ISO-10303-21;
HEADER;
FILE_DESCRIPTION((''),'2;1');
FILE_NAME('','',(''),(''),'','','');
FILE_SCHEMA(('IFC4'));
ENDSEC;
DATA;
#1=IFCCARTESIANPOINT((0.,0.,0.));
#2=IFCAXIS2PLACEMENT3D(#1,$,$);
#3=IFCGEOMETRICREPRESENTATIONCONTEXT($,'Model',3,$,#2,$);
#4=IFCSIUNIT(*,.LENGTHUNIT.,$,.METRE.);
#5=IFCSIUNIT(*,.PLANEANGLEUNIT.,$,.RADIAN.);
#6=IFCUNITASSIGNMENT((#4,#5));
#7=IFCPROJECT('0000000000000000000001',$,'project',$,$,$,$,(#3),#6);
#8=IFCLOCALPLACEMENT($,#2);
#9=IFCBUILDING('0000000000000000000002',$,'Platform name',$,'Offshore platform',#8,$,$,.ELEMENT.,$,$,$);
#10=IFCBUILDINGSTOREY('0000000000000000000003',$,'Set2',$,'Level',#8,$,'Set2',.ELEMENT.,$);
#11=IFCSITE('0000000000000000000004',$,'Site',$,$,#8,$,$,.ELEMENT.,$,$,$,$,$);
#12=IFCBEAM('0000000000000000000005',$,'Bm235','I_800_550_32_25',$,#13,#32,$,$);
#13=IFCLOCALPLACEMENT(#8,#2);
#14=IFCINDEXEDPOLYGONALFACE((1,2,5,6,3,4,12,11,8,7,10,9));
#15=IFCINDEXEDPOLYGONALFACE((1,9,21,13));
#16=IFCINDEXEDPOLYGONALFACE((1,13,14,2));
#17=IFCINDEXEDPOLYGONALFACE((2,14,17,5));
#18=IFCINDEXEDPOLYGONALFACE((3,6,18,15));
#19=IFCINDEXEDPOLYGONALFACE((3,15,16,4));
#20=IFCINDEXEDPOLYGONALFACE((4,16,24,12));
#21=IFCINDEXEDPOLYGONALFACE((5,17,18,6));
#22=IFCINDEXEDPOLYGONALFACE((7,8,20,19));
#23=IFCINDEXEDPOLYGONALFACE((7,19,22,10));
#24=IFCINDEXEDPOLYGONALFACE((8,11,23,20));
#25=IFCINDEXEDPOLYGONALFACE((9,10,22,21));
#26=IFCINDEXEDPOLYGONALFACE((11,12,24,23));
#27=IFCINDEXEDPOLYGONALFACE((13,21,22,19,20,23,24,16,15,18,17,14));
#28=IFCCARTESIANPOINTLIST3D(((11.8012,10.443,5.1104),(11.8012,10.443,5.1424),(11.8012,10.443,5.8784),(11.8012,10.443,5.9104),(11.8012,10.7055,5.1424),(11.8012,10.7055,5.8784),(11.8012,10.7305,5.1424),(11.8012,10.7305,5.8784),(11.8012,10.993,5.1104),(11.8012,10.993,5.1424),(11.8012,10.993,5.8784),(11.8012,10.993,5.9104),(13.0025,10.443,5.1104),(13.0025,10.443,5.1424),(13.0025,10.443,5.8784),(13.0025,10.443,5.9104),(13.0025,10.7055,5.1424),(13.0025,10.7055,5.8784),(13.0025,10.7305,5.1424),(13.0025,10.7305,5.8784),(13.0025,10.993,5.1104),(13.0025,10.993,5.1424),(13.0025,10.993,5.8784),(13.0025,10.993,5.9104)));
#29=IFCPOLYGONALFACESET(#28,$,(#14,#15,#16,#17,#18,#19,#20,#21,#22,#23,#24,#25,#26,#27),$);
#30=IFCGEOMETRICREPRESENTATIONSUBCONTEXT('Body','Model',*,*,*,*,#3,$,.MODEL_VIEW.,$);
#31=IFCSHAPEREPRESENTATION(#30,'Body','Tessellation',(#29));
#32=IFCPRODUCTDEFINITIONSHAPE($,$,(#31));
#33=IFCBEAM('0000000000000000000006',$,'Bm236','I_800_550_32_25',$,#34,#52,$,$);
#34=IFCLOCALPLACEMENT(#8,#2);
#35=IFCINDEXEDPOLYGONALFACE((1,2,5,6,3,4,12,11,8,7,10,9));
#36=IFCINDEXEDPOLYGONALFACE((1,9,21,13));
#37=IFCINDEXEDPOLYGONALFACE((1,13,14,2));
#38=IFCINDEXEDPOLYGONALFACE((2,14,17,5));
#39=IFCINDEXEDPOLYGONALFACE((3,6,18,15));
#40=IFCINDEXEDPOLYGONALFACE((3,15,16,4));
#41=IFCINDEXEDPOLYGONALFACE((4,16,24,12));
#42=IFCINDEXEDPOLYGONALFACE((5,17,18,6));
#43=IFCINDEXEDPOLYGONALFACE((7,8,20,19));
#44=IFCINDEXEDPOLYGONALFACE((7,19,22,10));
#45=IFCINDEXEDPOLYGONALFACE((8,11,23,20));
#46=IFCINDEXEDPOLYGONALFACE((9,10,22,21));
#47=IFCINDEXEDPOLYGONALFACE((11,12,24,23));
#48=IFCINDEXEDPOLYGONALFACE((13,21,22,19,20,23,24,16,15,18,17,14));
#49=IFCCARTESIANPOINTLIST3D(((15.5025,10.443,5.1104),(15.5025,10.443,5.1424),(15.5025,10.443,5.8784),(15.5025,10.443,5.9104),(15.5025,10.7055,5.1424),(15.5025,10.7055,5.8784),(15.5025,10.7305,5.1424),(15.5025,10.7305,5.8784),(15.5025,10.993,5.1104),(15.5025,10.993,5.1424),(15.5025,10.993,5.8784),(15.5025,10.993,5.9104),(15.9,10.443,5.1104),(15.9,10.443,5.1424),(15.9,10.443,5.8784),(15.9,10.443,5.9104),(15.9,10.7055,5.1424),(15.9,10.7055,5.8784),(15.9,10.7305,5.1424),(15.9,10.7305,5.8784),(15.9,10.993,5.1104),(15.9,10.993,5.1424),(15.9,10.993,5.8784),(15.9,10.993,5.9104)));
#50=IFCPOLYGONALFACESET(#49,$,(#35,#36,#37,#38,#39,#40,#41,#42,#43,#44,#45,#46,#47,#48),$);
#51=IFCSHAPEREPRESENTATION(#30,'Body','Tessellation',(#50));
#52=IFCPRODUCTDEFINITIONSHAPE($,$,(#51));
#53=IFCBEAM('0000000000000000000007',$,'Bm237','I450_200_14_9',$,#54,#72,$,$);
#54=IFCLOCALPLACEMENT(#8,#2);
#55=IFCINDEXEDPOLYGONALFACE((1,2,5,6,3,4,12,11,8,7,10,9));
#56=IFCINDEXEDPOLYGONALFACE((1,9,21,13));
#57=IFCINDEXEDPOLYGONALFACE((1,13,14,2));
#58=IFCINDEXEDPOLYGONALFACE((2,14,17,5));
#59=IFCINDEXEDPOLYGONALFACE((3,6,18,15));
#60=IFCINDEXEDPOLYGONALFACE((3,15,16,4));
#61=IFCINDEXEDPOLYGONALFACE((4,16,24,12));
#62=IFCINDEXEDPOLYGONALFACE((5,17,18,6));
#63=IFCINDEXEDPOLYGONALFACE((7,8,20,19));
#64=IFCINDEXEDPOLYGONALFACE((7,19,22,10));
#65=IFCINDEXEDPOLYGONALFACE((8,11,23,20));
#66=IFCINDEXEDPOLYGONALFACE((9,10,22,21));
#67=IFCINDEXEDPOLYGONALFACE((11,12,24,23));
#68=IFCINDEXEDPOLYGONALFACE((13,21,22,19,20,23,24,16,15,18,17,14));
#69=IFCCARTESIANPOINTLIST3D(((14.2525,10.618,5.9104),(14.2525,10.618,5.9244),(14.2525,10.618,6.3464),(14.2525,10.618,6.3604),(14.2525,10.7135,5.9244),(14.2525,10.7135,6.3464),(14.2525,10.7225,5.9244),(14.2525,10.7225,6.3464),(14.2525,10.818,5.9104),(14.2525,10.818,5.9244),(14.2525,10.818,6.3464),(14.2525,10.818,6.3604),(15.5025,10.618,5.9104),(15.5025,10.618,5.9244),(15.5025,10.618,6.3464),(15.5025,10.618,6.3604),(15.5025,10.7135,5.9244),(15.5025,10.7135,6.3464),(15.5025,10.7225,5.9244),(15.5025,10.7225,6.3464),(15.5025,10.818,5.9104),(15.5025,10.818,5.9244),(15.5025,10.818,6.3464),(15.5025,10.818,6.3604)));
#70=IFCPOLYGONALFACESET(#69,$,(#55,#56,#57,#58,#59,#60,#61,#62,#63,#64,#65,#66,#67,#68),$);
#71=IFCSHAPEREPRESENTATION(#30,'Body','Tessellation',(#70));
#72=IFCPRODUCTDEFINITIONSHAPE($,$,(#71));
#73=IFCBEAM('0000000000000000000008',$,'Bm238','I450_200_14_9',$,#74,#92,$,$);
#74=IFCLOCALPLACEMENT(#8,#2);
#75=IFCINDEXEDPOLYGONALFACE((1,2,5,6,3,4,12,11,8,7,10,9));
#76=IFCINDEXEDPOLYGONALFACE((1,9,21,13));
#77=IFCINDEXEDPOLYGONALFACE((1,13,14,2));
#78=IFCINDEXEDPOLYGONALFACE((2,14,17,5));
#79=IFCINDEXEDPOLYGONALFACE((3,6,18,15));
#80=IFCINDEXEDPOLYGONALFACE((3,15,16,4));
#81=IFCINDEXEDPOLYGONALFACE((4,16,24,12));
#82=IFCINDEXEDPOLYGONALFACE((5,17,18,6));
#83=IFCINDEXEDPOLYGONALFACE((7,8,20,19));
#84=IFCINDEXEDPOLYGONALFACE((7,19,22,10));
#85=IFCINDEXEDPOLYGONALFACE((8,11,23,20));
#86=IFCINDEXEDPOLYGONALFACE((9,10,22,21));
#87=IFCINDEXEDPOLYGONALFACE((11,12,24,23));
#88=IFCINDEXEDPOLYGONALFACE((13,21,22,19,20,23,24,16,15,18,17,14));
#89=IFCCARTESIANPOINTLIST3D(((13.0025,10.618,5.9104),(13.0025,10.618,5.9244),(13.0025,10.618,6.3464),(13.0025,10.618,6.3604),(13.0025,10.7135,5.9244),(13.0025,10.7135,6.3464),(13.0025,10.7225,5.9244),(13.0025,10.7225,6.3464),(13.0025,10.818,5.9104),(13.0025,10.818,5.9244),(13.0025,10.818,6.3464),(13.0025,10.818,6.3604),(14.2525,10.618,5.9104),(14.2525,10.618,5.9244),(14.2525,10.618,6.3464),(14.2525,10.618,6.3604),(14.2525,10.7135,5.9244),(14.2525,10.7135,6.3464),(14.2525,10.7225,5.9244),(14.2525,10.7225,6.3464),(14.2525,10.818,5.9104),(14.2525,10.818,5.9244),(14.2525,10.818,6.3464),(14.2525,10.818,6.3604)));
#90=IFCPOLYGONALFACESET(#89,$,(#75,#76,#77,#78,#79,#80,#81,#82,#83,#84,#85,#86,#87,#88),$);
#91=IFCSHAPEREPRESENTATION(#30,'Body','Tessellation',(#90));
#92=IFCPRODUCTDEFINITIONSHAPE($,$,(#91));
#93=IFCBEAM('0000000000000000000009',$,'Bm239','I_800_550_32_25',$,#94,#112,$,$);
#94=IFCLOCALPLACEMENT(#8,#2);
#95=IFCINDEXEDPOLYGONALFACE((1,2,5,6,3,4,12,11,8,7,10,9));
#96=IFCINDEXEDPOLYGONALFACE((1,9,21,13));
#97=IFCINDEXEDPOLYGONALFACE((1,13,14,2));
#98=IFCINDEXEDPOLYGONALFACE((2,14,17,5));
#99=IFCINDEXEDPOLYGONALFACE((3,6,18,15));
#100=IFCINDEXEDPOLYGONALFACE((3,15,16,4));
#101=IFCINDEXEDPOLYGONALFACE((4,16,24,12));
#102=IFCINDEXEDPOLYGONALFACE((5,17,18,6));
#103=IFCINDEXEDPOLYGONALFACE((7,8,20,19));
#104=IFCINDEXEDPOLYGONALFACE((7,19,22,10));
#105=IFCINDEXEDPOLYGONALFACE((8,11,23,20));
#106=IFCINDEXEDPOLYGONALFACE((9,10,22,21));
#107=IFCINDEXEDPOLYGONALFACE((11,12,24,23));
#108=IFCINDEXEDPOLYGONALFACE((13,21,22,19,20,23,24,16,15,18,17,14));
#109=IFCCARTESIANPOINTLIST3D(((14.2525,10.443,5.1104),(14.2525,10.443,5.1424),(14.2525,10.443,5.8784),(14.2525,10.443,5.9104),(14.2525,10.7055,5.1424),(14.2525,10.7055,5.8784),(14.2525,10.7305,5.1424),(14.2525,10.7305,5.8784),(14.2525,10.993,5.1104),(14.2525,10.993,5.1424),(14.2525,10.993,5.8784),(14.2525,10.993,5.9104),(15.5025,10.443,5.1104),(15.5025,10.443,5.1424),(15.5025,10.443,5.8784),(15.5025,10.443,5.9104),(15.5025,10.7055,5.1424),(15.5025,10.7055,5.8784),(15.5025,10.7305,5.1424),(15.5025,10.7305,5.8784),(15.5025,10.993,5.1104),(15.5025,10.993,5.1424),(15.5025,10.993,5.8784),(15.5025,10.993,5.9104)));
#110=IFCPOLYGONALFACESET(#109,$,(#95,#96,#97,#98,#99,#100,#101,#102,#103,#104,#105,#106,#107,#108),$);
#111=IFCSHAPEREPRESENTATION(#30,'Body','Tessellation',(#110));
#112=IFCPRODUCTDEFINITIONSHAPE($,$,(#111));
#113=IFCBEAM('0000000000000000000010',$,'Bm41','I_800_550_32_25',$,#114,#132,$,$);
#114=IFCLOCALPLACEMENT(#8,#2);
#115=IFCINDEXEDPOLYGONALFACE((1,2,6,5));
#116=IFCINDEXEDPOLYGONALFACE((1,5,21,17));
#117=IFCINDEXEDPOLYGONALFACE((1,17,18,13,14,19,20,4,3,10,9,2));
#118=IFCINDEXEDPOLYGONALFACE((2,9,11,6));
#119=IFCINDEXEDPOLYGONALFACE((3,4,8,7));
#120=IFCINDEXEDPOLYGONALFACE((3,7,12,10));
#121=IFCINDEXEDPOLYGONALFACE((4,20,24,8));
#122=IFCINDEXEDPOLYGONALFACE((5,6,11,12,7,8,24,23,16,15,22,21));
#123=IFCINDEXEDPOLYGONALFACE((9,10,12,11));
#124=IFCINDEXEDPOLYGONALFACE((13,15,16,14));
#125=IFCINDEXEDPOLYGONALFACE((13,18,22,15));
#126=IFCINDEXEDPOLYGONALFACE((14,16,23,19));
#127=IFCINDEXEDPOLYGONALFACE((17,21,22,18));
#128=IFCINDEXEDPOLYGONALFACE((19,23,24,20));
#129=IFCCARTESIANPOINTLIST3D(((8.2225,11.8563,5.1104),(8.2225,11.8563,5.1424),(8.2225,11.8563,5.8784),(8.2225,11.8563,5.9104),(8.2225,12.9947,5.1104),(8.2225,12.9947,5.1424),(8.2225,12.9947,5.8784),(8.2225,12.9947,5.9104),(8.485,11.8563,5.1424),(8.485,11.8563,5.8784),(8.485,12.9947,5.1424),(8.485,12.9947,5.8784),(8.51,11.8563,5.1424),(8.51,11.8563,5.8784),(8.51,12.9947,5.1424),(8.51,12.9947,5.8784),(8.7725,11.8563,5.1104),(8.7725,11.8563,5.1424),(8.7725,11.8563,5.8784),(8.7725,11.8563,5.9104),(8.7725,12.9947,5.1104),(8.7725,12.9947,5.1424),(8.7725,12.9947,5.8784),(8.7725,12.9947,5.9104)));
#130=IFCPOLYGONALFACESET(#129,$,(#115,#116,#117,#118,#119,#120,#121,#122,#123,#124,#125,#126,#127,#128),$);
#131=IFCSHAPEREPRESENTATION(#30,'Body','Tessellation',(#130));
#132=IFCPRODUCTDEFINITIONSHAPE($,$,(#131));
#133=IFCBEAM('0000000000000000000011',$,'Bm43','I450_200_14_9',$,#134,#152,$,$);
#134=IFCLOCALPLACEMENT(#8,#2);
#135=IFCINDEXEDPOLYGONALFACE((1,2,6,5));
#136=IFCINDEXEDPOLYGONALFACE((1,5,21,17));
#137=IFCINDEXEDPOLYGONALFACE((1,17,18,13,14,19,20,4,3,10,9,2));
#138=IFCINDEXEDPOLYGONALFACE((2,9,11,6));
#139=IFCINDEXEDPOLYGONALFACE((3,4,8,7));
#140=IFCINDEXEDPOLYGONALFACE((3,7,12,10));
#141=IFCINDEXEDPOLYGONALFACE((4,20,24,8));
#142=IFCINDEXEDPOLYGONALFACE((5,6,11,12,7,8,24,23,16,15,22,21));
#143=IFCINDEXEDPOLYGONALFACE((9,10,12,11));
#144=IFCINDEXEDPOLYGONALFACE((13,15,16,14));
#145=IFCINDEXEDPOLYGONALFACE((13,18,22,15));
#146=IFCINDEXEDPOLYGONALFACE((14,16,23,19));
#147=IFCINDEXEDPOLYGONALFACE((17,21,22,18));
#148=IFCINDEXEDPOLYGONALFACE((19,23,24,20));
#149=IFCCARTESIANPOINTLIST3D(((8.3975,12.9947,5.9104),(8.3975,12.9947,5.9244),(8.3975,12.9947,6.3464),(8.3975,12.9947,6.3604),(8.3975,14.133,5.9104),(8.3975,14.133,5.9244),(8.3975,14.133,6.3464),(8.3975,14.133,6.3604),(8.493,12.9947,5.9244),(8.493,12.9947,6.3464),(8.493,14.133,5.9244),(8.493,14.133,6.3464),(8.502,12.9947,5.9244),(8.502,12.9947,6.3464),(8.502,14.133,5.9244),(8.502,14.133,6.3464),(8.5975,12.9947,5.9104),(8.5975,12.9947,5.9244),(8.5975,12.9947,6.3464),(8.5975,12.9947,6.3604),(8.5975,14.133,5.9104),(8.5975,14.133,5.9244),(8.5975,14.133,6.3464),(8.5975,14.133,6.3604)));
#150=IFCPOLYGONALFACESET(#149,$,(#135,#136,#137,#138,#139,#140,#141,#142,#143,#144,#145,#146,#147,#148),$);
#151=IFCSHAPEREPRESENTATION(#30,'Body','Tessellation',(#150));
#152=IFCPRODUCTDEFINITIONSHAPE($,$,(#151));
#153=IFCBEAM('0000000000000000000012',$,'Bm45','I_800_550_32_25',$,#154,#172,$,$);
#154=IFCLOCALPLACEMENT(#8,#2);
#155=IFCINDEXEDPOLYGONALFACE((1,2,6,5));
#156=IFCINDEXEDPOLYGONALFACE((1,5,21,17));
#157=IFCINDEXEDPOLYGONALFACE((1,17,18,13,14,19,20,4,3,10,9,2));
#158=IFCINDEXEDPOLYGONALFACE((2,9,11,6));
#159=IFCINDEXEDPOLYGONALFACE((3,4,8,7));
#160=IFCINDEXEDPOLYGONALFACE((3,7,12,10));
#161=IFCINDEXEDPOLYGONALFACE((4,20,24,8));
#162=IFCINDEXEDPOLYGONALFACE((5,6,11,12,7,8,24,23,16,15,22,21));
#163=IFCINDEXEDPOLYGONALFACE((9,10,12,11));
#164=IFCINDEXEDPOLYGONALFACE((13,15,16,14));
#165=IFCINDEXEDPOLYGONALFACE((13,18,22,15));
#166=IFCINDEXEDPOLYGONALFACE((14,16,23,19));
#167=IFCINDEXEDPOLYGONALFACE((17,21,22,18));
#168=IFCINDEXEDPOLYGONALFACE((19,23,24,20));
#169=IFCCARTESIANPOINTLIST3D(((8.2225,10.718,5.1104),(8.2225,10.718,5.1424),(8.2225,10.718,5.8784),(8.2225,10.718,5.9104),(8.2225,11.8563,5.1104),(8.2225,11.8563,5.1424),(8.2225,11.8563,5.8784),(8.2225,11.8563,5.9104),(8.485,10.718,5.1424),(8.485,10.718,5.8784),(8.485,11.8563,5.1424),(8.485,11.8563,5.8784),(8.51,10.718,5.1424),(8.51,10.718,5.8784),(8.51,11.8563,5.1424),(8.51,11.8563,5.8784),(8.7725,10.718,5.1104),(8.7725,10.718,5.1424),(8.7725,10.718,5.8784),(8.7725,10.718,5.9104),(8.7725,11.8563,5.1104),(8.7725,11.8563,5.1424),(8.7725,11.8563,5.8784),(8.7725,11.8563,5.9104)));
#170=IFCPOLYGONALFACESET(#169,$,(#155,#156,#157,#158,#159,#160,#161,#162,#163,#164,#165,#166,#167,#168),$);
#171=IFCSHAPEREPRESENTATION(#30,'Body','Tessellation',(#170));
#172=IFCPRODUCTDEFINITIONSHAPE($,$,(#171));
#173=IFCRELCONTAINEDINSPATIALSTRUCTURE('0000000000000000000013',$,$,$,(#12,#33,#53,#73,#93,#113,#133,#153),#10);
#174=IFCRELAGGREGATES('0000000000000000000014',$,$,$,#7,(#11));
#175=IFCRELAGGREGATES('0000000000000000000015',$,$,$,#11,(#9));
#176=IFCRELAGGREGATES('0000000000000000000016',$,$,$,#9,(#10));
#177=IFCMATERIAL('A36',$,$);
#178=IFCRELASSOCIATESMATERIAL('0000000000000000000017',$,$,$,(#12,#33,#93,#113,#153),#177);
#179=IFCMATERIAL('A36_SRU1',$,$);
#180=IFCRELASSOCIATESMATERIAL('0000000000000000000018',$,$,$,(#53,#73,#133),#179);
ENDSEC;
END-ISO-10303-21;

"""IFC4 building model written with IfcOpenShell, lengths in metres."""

from ifc_helpers import new_model, si_unit, frame, origin, origin_2d, place, context, subcontext, project, spatial, i_section, extrude, source, transform, mapped, material, element, save


model = new_model("IFC4")

# Units and contexts
model_context = context("Model", 3, world=origin())
body_context = subcontext(model_context, "Body", "Model", "MODEL_VIEW")
ifc_project = project(units=[si_unit("LENGTHUNIT", "METRE"), si_unit("PLANEANGLEUNIT", "RADIAN")], contexts=[model_context])

# Site, building, storey
placement_1 = place(None, origin())
site = spatial("IfcSite", under=ifc_project, at=placement_1, Name="Site", CompositionType="ELEMENT")
building = spatial("IfcBuilding", under=site, at=placement_1, Name="Platform name", ObjectType="Offshore platform", CompositionType="ELEMENT")
storey = spatial("IfcBuildingStorey", under=building, at=placement_1, Name="Set2", ObjectType="Level", LongName="Set2", CompositionType="ELEMENT")

# Beams
ifc_material_1 = material(Name="A36_SRU1")
ifc_material_2 = material(Name="A36")
shared_shape_1 = source(origin(), body_context, "Body", "SweptSolid", [
    extrude(i_section(OverallWidth=0.55, OverallDepth=0.8, WebThickness=0.025, FlangeThickness=0.032, FilletRadius=0.0, at=origin_2d()), frame((0.0, 0.0, 0.0), z_axis=(1.0, 0.0, 0.0), x_axis=(0.0, 1.0, 0.0)), (0.0, 0.0, 1.0), 1.2012),
])
placement_2 = place(None, origin())
placement_3 = place(placement_2, origin())
placement_4 = place(placement_3, origin())
beam_1_placement = place(placement_4, frame((11.8012, 10.718, 5.5104)))
element("IfcBeam", 1, at=beam_1_placement, inside=storey, material=ifc_material_2, Name="Bm235", Description="I_800_550_32_25", context=body_context, shape_type="MappedRepresentation", body=[
    mapped(shared_shape_1, transform((0.0, 0.0, 0.0), scale=1.0)),
])
shared_shape_2 = source(origin(), body_context, "Body", "SweptSolid", [
    extrude(i_section(OverallWidth=0.55, OverallDepth=0.8, WebThickness=0.025, FlangeThickness=0.032, FilletRadius=0.0, at=origin_2d()), frame((0.0, 0.0, 0.0), z_axis=(1.0, 0.0, 0.0), x_axis=(0.0, 1.0, 0.0)), (0.0, 0.0, 1.0), 0.3975),
])
placement_5 = place(None, origin())
placement_6 = place(placement_5, origin())
placement_7 = place(placement_6, origin())
beam_2_placement = place(placement_7, frame((15.5025, 10.718, 5.5104)))
element("IfcBeam", 2, at=beam_2_placement, inside=storey, material=ifc_material_2, Name="Bm236", Description="I_800_550_32_25", context=body_context, shape_type="MappedRepresentation", body=[
    mapped(shared_shape_2, transform((0.0, 0.0, 0.0), scale=1.0)),
])
shared_shape_3 = source(origin(), body_context, "Body", "SweptSolid", [
    extrude(i_section(OverallWidth=0.2, OverallDepth=0.45, WebThickness=0.009, FlangeThickness=0.014, FilletRadius=0.0, at=origin_2d()), frame((0.0, 0.0, 0.0), z_axis=(-1.0, 0.0, 0.0), x_axis=(0.0, -1.0, 0.0)), (0.0, 0.0, 1.0), 1.25),
])
placement_8 = place(None, origin())
placement_9 = place(placement_8, origin())
placement_10 = place(placement_9, origin())
beam_3_placement = place(placement_10, frame((15.5025, 10.718, 6.1354)))
element("IfcBeam", 3, at=beam_3_placement, inside=storey, material=ifc_material_1, Name="Bm237", Description="I450_200_14_9", context=body_context, shape_type="MappedRepresentation", body=[
    mapped(shared_shape_3, transform((0.0, 0.0, 0.0), scale=1.0)),
])
shared_shape_4 = source(origin(), body_context, "Body", "SweptSolid", [
    extrude(i_section(OverallWidth=0.2, OverallDepth=0.45, WebThickness=0.009, FlangeThickness=0.014, FilletRadius=0.0, at=origin_2d()), frame((0.0, 0.0, 0.0), z_axis=(-1.0, 0.0, 0.0), x_axis=(0.0, -1.0, 0.0)), (0.0, 0.0, 1.0), 1.25),
])
placement_11 = place(None, origin())
placement_12 = place(placement_11, origin())
placement_13 = place(placement_12, origin())
beam_4_placement = place(placement_13, frame((14.2525, 10.718, 6.1354)))
element("IfcBeam", 4, at=beam_4_placement, inside=storey, material=ifc_material_1, Name="Bm238", Description="I450_200_14_9", context=body_context, shape_type="MappedRepresentation", body=[
    mapped(shared_shape_4, transform((0.0, 0.0, 0.0), scale=1.0)),
])
shared_shape_5 = source(origin(), body_context, "Body", "SweptSolid", [
    extrude(i_section(OverallWidth=0.55, OverallDepth=0.8, WebThickness=0.025, FlangeThickness=0.032, FilletRadius=0.0, at=origin_2d()), frame((0.0, 0.0, 0.0), z_axis=(1.0, 0.0, 0.0), x_axis=(0.0, 1.0, 0.0)), (0.0, 0.0, 1.0), 1.25),
])
placement_14 = place(None, origin())
placement_15 = place(placement_14, origin())
placement_16 = place(placement_15, origin())
beam_5_placement = place(placement_16, frame((14.2525, 10.718, 5.5104)))
element("IfcBeam", 5, at=beam_5_placement, inside=storey, material=ifc_material_2, Name="Bm239", Description="I_800_550_32_25", context=body_context, shape_type="MappedRepresentation", body=[
    mapped(shared_shape_5, transform((0.0, 0.0, 0.0), scale=1.0)),
])
shared_shape_6 = source(origin(), body_context, "Body", "SweptSolid", [
    extrude(i_section(OverallWidth=0.55, OverallDepth=0.8, WebThickness=0.025, FlangeThickness=0.032, FilletRadius=0.0, at=origin_2d()), frame((0.0, 0.0, 0.0), z_axis=(0.0, -1.0, 0.0), x_axis=(1.0, 0.0, 0.0)), (0.0, 0.0, 1.0), 1.1383),
])
placement_17 = place(None, origin())
placement_18 = place(placement_17, origin())
placement_19 = place(placement_18, origin())
beam_6_placement = place(placement_19, frame((8.4975, 12.9947, 5.5104)))
element("IfcBeam", 6, at=beam_6_placement, inside=storey, material=ifc_material_2, Name="Bm41", Description="I_800_550_32_25", context=body_context, shape_type="MappedRepresentation", body=[
    mapped(shared_shape_6, transform((0.0, 0.0, 0.0), scale=1.0)),
])
shared_shape_7 = source(origin(), body_context, "Body", "SweptSolid", [
    extrude(i_section(OverallWidth=0.2, OverallDepth=0.45, WebThickness=0.009, FlangeThickness=0.014, FilletRadius=0.0, at=origin_2d()), frame((0.0, 0.0, 0.0), z_axis=(0.0, 1.0, 0.0), x_axis=(-1.0, 0.0, 0.0)), (0.0, 0.0, 1.0), 1.1383),
])
placement_20 = place(None, origin())
placement_21 = place(placement_20, origin())
placement_22 = place(placement_21, origin())
beam_7_placement = place(placement_22, frame((8.4975, 12.9947, 6.1354)))
element("IfcBeam", 7, at=beam_7_placement, inside=storey, material=ifc_material_1, Name="Bm43", Description="I450_200_14_9", context=body_context, shape_type="MappedRepresentation", body=[
    mapped(shared_shape_7, transform((0.0, 0.0, 0.0), scale=1.0)),
])
shared_shape_8 = source(origin(), body_context, "Body", "SweptSolid", [
    extrude(i_section(OverallWidth=0.55, OverallDepth=0.8, WebThickness=0.025, FlangeThickness=0.032, FilletRadius=0.0, at=origin_2d()), frame((0.0, 0.0, 0.0), z_axis=(0.0, -1.0, 0.0), x_axis=(1.0, 0.0, 0.0)), (0.0, 0.0, 1.0), 1.1383),
])
placement_23 = place(None, origin())
placement_24 = place(placement_23, origin())
placement_25 = place(placement_24, origin())
beam_8_placement = place(placement_25, frame((8.4975, 11.8563, 5.5104)))
element("IfcBeam", 8, at=beam_8_placement, inside=storey, material=ifc_material_2, Name="Bm45", Description="I_800_550_32_25", context=body_context, shape_type="MappedRepresentation", body=[
    mapped(shared_shape_8, transform((0.0, 0.0, 0.0), scale=1.0)),
])

save(model, "model.ifc")
